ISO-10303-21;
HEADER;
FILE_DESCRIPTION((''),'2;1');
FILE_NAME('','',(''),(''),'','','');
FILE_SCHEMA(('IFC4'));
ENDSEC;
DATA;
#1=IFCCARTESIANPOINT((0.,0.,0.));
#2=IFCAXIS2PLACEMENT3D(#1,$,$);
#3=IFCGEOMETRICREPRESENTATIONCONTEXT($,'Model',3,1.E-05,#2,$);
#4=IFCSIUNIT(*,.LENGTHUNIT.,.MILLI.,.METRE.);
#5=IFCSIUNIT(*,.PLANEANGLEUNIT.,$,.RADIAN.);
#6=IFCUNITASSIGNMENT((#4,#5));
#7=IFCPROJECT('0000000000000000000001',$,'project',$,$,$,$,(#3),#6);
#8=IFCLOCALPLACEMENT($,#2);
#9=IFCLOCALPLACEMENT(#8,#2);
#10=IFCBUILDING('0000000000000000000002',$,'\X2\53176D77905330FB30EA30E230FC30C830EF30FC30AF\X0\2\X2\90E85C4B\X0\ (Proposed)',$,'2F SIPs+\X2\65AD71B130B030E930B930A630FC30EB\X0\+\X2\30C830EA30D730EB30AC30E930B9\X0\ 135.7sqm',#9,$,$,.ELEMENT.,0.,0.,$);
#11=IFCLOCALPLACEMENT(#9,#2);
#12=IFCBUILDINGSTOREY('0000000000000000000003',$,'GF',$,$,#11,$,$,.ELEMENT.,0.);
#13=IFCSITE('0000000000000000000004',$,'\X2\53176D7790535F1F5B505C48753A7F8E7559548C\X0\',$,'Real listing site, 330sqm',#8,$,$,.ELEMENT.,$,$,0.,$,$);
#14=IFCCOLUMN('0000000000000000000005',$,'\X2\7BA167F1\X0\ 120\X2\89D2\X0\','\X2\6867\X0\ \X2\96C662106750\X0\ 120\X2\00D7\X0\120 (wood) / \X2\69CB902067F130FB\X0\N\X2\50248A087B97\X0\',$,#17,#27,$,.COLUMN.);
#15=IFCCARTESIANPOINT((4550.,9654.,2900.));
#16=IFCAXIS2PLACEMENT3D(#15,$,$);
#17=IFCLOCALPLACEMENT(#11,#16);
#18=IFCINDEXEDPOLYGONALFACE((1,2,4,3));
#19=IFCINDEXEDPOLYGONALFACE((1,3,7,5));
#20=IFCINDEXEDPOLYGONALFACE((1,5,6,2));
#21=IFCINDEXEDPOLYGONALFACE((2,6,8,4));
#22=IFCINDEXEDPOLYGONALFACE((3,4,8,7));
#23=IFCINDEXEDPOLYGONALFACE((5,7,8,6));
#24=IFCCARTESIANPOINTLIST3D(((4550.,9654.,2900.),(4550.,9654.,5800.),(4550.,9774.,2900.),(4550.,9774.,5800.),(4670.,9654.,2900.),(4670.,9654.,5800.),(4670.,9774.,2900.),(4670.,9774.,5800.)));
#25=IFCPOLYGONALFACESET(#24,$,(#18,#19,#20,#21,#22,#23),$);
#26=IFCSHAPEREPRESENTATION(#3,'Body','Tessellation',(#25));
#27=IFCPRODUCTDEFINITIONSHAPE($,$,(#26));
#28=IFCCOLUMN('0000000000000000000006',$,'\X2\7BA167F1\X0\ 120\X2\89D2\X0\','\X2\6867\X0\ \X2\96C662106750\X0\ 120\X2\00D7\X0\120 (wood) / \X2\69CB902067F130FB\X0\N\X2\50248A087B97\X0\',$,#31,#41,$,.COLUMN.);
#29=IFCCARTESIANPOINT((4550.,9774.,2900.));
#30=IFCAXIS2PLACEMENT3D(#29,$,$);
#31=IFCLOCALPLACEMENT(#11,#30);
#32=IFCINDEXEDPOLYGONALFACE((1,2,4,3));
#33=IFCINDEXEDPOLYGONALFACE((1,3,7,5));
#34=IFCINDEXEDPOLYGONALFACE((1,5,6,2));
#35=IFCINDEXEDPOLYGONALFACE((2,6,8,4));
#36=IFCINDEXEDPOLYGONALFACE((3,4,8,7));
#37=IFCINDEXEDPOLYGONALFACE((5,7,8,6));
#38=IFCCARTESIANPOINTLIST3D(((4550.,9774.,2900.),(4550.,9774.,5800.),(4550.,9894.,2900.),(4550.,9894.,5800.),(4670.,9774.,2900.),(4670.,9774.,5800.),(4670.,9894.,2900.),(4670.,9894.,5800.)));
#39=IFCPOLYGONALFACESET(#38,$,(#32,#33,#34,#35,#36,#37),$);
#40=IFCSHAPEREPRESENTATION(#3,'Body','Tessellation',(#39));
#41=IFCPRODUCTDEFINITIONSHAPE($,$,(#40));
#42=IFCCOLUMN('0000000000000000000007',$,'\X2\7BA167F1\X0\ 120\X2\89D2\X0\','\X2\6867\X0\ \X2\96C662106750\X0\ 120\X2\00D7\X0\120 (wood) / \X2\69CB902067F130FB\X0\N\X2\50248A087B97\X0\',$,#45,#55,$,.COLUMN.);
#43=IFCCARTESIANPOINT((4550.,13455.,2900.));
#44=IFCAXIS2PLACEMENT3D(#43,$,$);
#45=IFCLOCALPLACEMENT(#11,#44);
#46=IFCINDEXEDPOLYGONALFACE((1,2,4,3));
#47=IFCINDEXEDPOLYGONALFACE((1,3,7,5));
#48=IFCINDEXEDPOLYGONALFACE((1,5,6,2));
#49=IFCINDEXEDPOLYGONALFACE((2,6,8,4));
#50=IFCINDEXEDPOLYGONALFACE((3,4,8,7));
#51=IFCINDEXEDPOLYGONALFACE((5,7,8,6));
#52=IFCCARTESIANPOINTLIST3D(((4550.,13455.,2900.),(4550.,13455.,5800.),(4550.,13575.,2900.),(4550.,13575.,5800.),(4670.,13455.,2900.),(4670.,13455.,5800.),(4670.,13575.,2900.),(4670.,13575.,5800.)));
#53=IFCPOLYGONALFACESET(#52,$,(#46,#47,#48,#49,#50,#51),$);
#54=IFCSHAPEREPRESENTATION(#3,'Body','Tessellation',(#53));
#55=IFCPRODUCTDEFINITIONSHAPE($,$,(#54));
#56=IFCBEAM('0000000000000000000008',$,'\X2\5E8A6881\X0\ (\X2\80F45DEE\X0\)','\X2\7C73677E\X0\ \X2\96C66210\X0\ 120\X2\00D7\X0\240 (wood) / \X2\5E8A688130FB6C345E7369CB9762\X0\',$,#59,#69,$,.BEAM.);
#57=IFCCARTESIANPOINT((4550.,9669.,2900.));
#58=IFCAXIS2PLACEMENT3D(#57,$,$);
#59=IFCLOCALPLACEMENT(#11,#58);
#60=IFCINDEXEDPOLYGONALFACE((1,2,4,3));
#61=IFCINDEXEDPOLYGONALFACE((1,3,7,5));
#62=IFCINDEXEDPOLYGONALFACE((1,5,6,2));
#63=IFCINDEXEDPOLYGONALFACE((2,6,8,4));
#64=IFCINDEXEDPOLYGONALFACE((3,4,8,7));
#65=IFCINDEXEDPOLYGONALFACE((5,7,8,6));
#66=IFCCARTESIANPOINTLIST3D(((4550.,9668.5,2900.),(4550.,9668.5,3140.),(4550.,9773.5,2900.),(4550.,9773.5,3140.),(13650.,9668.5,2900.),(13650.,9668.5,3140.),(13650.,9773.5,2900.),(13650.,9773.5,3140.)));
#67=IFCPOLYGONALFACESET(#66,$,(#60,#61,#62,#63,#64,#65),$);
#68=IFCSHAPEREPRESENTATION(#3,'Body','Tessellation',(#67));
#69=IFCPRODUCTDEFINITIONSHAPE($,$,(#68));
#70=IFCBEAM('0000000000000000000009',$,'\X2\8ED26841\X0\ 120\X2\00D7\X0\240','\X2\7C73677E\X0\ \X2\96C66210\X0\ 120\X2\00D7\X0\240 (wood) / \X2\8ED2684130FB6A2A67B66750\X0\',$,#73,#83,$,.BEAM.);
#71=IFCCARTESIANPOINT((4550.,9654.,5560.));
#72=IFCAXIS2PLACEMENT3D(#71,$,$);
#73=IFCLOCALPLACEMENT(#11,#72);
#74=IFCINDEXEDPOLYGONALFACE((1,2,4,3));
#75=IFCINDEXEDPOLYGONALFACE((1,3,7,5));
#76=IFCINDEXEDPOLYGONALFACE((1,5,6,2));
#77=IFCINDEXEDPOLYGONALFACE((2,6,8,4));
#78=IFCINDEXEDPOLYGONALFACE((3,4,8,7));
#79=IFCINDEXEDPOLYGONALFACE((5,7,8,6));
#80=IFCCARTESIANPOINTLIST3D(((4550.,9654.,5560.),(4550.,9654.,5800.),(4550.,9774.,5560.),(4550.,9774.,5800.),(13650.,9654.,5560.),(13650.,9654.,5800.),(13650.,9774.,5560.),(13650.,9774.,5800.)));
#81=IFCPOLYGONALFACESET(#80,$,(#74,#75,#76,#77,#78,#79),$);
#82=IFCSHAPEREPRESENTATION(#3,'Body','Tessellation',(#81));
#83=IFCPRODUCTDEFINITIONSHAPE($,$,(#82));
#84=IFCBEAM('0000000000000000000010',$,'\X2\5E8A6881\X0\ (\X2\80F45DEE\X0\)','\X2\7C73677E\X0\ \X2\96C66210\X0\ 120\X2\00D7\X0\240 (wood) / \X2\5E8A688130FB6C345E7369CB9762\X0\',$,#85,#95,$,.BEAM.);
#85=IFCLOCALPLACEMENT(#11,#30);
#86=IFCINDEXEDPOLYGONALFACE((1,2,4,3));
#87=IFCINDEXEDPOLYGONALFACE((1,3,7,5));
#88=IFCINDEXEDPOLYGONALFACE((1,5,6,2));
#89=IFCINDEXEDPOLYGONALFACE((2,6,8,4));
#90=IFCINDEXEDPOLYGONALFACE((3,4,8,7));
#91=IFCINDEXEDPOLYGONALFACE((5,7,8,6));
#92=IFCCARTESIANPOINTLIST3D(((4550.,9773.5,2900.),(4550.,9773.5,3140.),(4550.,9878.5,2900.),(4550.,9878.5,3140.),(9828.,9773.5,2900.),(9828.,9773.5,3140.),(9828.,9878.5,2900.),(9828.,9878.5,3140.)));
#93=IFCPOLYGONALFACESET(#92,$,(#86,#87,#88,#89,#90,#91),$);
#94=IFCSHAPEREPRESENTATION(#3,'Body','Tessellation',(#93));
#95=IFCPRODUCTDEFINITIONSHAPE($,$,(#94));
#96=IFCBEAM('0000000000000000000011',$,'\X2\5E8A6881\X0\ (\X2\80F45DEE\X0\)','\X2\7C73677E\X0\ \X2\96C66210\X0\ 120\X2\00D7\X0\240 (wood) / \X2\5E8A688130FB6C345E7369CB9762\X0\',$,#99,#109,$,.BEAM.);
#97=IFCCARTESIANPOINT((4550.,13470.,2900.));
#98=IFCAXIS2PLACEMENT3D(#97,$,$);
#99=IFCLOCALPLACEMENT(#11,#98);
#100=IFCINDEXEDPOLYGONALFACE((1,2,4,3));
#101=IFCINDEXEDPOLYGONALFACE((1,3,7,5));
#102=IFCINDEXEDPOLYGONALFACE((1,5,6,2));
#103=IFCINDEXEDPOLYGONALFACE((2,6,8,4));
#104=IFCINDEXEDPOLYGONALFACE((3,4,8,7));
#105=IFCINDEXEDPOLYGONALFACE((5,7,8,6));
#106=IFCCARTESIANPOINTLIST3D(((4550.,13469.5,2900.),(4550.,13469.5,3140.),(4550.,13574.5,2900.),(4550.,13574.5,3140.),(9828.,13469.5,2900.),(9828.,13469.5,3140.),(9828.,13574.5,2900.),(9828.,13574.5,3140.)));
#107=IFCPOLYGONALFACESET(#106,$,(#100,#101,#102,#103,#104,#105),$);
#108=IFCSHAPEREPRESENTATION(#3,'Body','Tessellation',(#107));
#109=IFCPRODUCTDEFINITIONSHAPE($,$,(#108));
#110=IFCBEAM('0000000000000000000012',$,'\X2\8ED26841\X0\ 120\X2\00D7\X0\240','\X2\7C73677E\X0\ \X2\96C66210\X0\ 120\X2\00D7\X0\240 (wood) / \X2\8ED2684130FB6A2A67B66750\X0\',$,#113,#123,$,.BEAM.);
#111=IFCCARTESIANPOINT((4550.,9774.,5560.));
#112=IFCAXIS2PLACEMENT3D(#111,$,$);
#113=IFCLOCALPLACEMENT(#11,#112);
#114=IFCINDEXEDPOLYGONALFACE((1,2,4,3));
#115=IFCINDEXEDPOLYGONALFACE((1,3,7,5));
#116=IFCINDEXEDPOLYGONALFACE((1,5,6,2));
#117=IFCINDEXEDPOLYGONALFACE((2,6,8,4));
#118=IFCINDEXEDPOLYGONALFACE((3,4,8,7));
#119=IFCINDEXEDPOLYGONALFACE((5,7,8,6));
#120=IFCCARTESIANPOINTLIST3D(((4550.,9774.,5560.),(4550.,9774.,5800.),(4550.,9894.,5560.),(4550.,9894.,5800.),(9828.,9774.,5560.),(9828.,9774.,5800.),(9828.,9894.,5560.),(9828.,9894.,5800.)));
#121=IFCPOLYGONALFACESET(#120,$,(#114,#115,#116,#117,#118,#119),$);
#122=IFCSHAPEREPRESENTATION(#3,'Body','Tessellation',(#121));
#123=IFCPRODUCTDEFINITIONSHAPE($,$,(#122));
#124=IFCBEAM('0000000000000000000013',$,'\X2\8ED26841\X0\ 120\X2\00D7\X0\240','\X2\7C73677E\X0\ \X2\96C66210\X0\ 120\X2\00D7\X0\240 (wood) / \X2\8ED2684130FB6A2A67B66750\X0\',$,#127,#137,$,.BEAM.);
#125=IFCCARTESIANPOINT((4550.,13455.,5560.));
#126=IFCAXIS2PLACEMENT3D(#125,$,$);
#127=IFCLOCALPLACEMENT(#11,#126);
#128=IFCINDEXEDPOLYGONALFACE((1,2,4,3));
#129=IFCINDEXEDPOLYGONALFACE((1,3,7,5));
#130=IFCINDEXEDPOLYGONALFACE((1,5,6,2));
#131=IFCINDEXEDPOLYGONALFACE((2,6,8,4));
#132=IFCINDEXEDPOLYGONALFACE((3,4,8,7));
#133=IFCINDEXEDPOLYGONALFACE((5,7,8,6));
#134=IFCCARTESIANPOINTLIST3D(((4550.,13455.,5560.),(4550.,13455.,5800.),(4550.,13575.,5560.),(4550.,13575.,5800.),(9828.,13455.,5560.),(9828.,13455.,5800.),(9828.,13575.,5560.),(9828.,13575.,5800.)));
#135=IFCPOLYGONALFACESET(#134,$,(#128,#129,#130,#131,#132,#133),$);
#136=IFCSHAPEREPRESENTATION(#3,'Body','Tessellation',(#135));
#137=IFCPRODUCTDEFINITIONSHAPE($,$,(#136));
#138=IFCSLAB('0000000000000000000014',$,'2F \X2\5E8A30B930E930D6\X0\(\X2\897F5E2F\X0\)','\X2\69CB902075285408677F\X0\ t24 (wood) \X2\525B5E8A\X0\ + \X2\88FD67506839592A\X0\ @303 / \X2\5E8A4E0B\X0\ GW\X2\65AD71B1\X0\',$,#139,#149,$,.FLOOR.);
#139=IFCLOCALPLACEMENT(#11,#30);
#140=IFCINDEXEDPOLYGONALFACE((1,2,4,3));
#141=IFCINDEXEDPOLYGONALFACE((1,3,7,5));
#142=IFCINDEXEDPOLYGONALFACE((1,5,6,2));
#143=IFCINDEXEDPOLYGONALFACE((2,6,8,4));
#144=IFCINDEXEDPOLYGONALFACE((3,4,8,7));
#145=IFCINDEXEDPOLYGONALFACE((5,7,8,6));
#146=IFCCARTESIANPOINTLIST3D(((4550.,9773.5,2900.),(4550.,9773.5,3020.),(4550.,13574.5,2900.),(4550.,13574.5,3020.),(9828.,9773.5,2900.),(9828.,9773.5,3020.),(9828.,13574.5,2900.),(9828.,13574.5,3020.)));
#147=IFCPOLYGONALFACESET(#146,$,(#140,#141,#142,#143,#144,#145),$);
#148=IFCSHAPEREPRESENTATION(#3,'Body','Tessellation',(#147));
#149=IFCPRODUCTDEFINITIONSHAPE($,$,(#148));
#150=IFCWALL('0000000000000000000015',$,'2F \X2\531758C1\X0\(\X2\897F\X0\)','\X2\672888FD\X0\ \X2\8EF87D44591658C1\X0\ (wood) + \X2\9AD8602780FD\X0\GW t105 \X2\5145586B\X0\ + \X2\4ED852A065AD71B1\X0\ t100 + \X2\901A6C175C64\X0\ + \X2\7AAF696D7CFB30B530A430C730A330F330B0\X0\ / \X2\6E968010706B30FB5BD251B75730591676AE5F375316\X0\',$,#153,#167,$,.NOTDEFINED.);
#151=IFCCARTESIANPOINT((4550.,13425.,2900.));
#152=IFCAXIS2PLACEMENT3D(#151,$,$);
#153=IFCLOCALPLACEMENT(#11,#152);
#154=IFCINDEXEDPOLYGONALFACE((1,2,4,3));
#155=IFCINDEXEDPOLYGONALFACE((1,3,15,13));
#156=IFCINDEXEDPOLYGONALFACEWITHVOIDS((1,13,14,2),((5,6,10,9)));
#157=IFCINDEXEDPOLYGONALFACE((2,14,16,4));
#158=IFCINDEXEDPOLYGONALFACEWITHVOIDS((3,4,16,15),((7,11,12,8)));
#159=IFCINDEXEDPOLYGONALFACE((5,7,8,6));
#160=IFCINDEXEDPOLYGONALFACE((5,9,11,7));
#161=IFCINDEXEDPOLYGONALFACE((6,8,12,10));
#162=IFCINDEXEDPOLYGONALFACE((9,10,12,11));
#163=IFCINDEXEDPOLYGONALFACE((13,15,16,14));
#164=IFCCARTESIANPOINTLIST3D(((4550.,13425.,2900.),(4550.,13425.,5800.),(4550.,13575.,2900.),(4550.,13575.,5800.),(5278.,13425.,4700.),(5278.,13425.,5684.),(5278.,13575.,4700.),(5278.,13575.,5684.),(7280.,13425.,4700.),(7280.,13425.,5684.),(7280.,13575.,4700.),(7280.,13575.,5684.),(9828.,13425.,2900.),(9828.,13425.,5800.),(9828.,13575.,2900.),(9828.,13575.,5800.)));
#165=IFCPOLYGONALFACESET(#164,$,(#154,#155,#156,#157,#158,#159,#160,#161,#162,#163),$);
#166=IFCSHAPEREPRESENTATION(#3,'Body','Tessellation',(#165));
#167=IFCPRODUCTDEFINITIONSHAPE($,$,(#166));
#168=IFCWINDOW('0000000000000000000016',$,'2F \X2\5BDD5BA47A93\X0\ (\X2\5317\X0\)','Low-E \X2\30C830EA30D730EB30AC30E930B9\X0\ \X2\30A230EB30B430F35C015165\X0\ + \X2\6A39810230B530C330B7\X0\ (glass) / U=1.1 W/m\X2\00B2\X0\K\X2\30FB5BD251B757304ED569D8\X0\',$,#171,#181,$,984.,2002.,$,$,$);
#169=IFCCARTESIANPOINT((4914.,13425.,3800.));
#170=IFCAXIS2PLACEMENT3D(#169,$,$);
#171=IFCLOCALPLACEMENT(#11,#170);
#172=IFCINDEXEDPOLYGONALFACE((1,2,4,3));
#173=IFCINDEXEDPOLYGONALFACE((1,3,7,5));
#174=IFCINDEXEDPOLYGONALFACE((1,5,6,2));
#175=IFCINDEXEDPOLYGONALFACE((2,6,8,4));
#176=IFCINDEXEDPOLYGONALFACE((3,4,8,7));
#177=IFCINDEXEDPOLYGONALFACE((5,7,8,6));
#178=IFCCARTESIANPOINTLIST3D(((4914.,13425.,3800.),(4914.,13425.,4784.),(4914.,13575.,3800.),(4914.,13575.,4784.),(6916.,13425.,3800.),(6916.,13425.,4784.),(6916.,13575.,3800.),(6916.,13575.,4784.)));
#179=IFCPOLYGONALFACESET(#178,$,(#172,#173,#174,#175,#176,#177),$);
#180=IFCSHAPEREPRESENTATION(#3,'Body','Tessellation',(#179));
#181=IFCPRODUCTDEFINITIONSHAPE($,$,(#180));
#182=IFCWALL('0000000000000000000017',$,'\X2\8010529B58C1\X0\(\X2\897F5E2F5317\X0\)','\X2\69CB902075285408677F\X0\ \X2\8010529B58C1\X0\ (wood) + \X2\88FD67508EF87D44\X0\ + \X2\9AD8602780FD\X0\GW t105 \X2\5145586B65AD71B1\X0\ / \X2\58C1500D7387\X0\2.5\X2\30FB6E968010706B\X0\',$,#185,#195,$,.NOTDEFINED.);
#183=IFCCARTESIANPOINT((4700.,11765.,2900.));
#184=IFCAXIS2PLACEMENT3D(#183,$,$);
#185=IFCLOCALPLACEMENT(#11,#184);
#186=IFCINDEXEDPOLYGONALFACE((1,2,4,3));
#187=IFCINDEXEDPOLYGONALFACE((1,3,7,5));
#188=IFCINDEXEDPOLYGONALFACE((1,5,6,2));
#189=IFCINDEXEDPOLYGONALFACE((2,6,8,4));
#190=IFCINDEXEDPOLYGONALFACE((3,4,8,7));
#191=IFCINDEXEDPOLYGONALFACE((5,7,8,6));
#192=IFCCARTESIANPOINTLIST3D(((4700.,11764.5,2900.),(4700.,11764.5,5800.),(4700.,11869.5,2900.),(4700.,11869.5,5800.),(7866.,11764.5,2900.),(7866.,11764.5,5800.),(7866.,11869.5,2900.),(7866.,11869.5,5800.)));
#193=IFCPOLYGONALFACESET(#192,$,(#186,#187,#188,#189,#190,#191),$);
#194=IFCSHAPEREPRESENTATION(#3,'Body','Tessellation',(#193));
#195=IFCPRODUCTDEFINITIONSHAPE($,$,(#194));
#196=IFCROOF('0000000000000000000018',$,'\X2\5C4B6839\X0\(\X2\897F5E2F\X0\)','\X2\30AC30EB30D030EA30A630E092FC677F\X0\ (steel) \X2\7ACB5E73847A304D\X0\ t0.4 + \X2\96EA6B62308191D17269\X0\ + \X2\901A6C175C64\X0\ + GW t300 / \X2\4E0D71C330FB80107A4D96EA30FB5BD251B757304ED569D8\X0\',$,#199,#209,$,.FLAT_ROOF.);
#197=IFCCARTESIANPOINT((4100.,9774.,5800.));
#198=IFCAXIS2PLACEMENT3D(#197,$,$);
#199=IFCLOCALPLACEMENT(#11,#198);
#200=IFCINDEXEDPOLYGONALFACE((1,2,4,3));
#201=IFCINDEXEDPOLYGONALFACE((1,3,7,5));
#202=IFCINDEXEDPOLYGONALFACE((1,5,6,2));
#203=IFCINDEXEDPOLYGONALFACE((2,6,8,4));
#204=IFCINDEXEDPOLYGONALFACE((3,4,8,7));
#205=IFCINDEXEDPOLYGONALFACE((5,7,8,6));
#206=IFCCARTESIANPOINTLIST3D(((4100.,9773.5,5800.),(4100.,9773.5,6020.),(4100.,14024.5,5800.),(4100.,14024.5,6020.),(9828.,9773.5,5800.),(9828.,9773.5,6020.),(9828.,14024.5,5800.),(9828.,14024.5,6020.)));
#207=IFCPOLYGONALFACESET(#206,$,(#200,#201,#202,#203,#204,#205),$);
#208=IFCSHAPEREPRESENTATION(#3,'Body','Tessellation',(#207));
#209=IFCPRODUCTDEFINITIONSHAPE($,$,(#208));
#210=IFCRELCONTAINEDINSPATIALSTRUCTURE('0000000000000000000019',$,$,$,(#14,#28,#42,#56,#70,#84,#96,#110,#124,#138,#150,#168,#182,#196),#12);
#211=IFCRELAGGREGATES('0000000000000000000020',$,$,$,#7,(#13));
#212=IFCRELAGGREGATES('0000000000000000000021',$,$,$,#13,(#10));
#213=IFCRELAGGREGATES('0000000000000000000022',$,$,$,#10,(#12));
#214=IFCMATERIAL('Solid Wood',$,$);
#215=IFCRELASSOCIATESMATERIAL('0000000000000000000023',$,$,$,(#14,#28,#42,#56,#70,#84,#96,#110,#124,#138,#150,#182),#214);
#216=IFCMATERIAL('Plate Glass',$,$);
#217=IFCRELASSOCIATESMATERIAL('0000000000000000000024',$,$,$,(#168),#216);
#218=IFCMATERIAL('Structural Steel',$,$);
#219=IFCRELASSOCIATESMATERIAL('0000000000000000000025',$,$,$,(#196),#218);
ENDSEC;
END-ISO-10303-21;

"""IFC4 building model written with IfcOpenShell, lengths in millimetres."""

from ifc_helpers import new_model, si_unit, frame, frame_2d, origin, place, context, project, spatial, rectangle, extrude, material, element, fill, save


model = new_model("IFC4")

# Units and contexts
model_context = context("Model", 3, precision=1e-05, world=origin())
ifc_project = project(units=[si_unit("LENGTHUNIT", "METRE", prefix="MILLI"), si_unit("PLANEANGLEUNIT", "RADIAN")], contexts=[model_context])

# Site, building, storey
site_placement = place(None, origin())
site = spatial("IfcSite", under=ifc_project, at=site_placement, Name="北海道弟子屈町美留和", ObjectType="Real listing site, 330sqm", CompositionType="ELEMENT", RefElevation=0.0)
building_placement = place(site_placement, origin())
building = spatial("IfcBuilding", under=site, at=building_placement, Name="北海道・リモートワーク2部屋 (Proposed)", ObjectType="2F SIPs+断熱グラスウール+トリプルガラス 135.7sqm", CompositionType="ELEMENT", ElevationOfRefHeight=0.0, ElevationOfTerrain=0.0)
storey_placement = place(building_placement, origin())
storey = spatial("IfcBuildingStorey", under=building, at=storey_placement, Name="GF", CompositionType="ELEMENT", Elevation=0.0)

# Columns
ifc_material_1 = material(Name="Solid Wood")
column_1_placement = place(storey_placement, frame((4550.0, 9654.0, 2900.0)))
element("IfcColumn", 1, at=column_1_placement, inside=storey, material=ifc_material_1, Name="管柱 120角", Description="桧 集成材 120×120 (wood) / 構造柱・N値計算", PredefinedType="COLUMN", context=model_context, shape_type="SweptSolid", body=[
    extrude(rectangle(XDim=120.0, YDim=120.0, at=frame_2d((60.0, 60.0))), frame((4550.0, 9654.0, 2900.0)), (0.0, 0.0, 1.0), 2900.0),
])
column_2_placement = place(storey_placement, frame((4550.0, 9774.0, 2900.0)))
element("IfcColumn", 2, at=column_2_placement, inside=storey, material=ifc_material_1, Name="管柱 120角", Description="桧 集成材 120×120 (wood) / 構造柱・N値計算", PredefinedType="COLUMN", context=model_context, shape_type="SweptSolid", body=[
    extrude(rectangle(XDim=120.0, YDim=120.0, at=frame_2d((60.0, 60.0))), frame((4550.0, 9774.0, 2900.0)), (0.0, 0.0, 1.0), 2900.0),
])
column_3_placement = place(storey_placement, frame((4550.0, 13455.0, 2900.0)))
element("IfcColumn", 3, at=column_3_placement, inside=storey, material=ifc_material_1, Name="管柱 120角", Description="桧 集成材 120×120 (wood) / 構造柱・N値計算", PredefinedType="COLUMN", context=model_context, shape_type="SweptSolid", body=[
    extrude(rectangle(XDim=120.0, YDim=120.0, at=frame_2d((60.0, 60.0))), frame((4550.0, 13455.0, 2900.0)), (0.0, 0.0, 1.0), 2900.0),
])

# Beams
beam_1_placement = place(storey_placement, frame((4550.0, 9669.0, 2900.0)))
element("IfcBeam", 4, at=beam_1_placement, inside=storey, material=ifc_material_1, Name="床梁 (胴差)", Description="米松 集成 120×240 (wood) / 床梁・水平構面", PredefinedType="BEAM", context=model_context, shape_type="SweptSolid", body=[
    extrude(rectangle(XDim=9100.0, YDim=105.0, at=frame_2d((4550.0, 52.0))), frame((4550.0, 9669.0, 2900.0)), (0.0, 0.0, 1.0), 240.0),
])
beam_2_placement = place(storey_placement, frame((4550.0, 9654.0, 5560.0)))
element("IfcBeam", 5, at=beam_2_placement, inside=storey, material=ifc_material_1, Name="軒桁 120×240", Description="米松 集成 120×240 (wood) / 軒桁・横架材", PredefinedType="BEAM", context=model_context, shape_type="SweptSolid", body=[
    extrude(rectangle(XDim=9100.0, YDim=120.0, at=frame_2d((4550.0, 60.0))), frame((4550.0, 9654.0, 5560.0)), (0.0, 0.0, 1.0), 240.0),
])
beam_3_placement = place(storey_placement, frame((4550.0, 9774.0, 2900.0)))
element("IfcBeam", 6, at=beam_3_placement, inside=storey, material=ifc_material_1, Name="床梁 (胴差)", Description="米松 集成 120×240 (wood) / 床梁・水平構面", PredefinedType="BEAM", context=model_context, shape_type="SweptSolid", body=[
    extrude(rectangle(XDim=5278.0, YDim=105.0, at=frame_2d((2639.0, 52.0))), frame((4550.0, 9774.0, 2900.0)), (0.0, 0.0, 1.0), 240.0),
])
beam_4_placement = place(storey_placement, frame((4550.0, 13470.0, 2900.0)))
element("IfcBeam", 7, at=beam_4_placement, inside=storey, material=ifc_material_1, Name="床梁 (胴差)", Description="米松 集成 120×240 (wood) / 床梁・水平構面", PredefinedType="BEAM", context=model_context, shape_type="SweptSolid", body=[
    extrude(rectangle(XDim=5278.0, YDim=105.0, at=frame_2d((2639.0, 52.0))), frame((4550.0, 13470.0, 2900.0)), (0.0, 0.0, 1.0), 240.0),
])
beam_5_placement = place(storey_placement, frame((4550.0, 9774.0, 5560.0)))
element("IfcBeam", 8, at=beam_5_placement, inside=storey, material=ifc_material_1, Name="軒桁 120×240", Description="米松 集成 120×240 (wood) / 軒桁・横架材", PredefinedType="BEAM", context=model_context, shape_type="SweptSolid", body=[
    extrude(rectangle(XDim=5278.0, YDim=120.0, at=frame_2d((2639.0, 60.0))), frame((4550.0, 9774.0, 5560.0)), (0.0, 0.0, 1.0), 240.0),
])
beam_6_placement = place(storey_placement, frame((4550.0, 13455.0, 5560.0)))
element("IfcBeam", 9, at=beam_6_placement, inside=storey, material=ifc_material_1, Name="軒桁 120×240", Description="米松 集成 120×240 (wood) / 軒桁・横架材", PredefinedType="BEAM", context=model_context, shape_type="SweptSolid", body=[
    extrude(rectangle(XDim=5278.0, YDim=120.0, at=frame_2d((2639.0, 60.0))), frame((4550.0, 13455.0, 5560.0)), (0.0, 0.0, 1.0), 240.0),
])

# Slab
slab_placement = place(storey_placement, frame((4550.0, 9774.0, 2900.0)))
element("IfcSlab", 10, at=slab_placement, inside=storey, material=ifc_material_1, Name="2F 床スラブ(西帯)", Description="構造用合板 t24 (wood) 剛床 + 製材根太 @303 / 床下 GW断熱", PredefinedType="FLOOR", context=model_context, shape_type="SweptSolid", body=[
    extrude(rectangle(XDim=5278.0, YDim=3801.0, at=frame_2d((2639.0, 1900.0))), frame((4550.0, 9774.0, 2900.0)), (0.0, 0.0, 1.0), 120.0),
])

# Wall, opening, window
wall_1_placement = place(storey_placement, frame((4550.0, 13425.0, 2900.0)))
wall_1 = element("IfcWall", 11, at=wall_1_placement, inside=storey, material=ifc_material_1, Name="2F 北壁(西)", Description="木製 軸組外壁 (wood) + 高性能GW t105 充填 + 付加断熱 t100 + 通気層 + 窯業系サイディング / 準耐火・寒冷地外皮強化", PredefinedType="NOTDEFINED", context=model_context, shape_type="SweptSolid", body=[
    extrude(rectangle(XDim=5278.0, YDim=150.0, at=frame_2d((2639.0, 75.0))), frame((4550.0, 13425.0, 2900.0)), (0.0, 0.0, 1.0), 2900.0),
])
opening_placement = place(storey_placement, frame((4914.0, 13425.0, 3800.0)))
opening = element("IfcOpeningElement", 12, at=opening_placement, cuts=wall_1, PredefinedType="NOTDEFINED", context=model_context, shape_type="SweptSolid", body=[
    extrude(rectangle(XDim=2002.0, YDim=150.0, at=frame_2d((1001.0, 75.0))), frame((4914.0, 13425.0, 3800.0)), (0.0, 0.0, 1.0), 984.0),
])
ifc_material_2 = material(Name="Plate Glass")
window_placement = place(storey_placement, frame((4914.0, 13425.0, 3800.0)))
window = element("IfcWindow", 13, at=window_placement, inside=storey, material=ifc_material_2, Name="2F 寝室窓 (北)", Description="Low-E トリプルガラス アルゴン封入 + 樹脂サッシ (glass) / U=1.1 W/m²K・寒冷地仕様", OverallHeight=984.0, OverallWidth=2002.0, context=model_context, shape_type="SweptSolid", body=[
    extrude(rectangle(XDim=2002.0, YDim=150.0, at=frame_2d((1001.0, 75.0))), frame((4914.0, 13425.0, 3800.0)), (0.0, 0.0, 1.0), 984.0),
])
fill(opening, window)

# Wall
wall_2_placement = place(storey_placement, frame((4700.0, 11765.0, 2900.0)))
element("IfcWall", 14, at=wall_2_placement, inside=storey, material=ifc_material_1, Name="耐力壁(西帯北)", Description="構造用合板 耐力壁 (wood) + 製材軸組 + 高性能GW t105 充填断熱 / 壁倍率2.5・準耐火", PredefinedType="NOTDEFINED", context=model_context, shape_type="SweptSolid", body=[
    extrude(rectangle(XDim=3166.0, YDim=105.0, at=frame_2d((1583.0, 52.0))), frame((4700.0, 11765.0, 2900.0)), (0.0, 0.0, 1.0), 2900.0),
])

# Roof
ifc_material_3 = material(Name="Structural Steel")
for number, where, name in (
    (15, (4100.0, 9774.0, 5800.0), "屋根(西帯)"),
):
    element("IfcRoof", number, at=place(storey_placement, frame(where)), inside=storey, material=ifc_material_3, Name=name, Description="ガルバリウム鋼板 (steel) 立平葺き t0.4 + 雪止め金物 + 通気層 + GW t300 / 不燃・耐積雪・寒冷地仕様", PredefinedType="FLAT_ROOF", context=model_context, shape_type="SweptSolid", body=[
        extrude(rectangle(XDim=5728.0, YDim=4251.0, at=frame_2d((2864.0, 2125.0))), frame((4100.0, 9774.0, 5800.0)), (0.0, 0.0, 1.0), 220.0),
    ])

save(model, "model.ifc")
